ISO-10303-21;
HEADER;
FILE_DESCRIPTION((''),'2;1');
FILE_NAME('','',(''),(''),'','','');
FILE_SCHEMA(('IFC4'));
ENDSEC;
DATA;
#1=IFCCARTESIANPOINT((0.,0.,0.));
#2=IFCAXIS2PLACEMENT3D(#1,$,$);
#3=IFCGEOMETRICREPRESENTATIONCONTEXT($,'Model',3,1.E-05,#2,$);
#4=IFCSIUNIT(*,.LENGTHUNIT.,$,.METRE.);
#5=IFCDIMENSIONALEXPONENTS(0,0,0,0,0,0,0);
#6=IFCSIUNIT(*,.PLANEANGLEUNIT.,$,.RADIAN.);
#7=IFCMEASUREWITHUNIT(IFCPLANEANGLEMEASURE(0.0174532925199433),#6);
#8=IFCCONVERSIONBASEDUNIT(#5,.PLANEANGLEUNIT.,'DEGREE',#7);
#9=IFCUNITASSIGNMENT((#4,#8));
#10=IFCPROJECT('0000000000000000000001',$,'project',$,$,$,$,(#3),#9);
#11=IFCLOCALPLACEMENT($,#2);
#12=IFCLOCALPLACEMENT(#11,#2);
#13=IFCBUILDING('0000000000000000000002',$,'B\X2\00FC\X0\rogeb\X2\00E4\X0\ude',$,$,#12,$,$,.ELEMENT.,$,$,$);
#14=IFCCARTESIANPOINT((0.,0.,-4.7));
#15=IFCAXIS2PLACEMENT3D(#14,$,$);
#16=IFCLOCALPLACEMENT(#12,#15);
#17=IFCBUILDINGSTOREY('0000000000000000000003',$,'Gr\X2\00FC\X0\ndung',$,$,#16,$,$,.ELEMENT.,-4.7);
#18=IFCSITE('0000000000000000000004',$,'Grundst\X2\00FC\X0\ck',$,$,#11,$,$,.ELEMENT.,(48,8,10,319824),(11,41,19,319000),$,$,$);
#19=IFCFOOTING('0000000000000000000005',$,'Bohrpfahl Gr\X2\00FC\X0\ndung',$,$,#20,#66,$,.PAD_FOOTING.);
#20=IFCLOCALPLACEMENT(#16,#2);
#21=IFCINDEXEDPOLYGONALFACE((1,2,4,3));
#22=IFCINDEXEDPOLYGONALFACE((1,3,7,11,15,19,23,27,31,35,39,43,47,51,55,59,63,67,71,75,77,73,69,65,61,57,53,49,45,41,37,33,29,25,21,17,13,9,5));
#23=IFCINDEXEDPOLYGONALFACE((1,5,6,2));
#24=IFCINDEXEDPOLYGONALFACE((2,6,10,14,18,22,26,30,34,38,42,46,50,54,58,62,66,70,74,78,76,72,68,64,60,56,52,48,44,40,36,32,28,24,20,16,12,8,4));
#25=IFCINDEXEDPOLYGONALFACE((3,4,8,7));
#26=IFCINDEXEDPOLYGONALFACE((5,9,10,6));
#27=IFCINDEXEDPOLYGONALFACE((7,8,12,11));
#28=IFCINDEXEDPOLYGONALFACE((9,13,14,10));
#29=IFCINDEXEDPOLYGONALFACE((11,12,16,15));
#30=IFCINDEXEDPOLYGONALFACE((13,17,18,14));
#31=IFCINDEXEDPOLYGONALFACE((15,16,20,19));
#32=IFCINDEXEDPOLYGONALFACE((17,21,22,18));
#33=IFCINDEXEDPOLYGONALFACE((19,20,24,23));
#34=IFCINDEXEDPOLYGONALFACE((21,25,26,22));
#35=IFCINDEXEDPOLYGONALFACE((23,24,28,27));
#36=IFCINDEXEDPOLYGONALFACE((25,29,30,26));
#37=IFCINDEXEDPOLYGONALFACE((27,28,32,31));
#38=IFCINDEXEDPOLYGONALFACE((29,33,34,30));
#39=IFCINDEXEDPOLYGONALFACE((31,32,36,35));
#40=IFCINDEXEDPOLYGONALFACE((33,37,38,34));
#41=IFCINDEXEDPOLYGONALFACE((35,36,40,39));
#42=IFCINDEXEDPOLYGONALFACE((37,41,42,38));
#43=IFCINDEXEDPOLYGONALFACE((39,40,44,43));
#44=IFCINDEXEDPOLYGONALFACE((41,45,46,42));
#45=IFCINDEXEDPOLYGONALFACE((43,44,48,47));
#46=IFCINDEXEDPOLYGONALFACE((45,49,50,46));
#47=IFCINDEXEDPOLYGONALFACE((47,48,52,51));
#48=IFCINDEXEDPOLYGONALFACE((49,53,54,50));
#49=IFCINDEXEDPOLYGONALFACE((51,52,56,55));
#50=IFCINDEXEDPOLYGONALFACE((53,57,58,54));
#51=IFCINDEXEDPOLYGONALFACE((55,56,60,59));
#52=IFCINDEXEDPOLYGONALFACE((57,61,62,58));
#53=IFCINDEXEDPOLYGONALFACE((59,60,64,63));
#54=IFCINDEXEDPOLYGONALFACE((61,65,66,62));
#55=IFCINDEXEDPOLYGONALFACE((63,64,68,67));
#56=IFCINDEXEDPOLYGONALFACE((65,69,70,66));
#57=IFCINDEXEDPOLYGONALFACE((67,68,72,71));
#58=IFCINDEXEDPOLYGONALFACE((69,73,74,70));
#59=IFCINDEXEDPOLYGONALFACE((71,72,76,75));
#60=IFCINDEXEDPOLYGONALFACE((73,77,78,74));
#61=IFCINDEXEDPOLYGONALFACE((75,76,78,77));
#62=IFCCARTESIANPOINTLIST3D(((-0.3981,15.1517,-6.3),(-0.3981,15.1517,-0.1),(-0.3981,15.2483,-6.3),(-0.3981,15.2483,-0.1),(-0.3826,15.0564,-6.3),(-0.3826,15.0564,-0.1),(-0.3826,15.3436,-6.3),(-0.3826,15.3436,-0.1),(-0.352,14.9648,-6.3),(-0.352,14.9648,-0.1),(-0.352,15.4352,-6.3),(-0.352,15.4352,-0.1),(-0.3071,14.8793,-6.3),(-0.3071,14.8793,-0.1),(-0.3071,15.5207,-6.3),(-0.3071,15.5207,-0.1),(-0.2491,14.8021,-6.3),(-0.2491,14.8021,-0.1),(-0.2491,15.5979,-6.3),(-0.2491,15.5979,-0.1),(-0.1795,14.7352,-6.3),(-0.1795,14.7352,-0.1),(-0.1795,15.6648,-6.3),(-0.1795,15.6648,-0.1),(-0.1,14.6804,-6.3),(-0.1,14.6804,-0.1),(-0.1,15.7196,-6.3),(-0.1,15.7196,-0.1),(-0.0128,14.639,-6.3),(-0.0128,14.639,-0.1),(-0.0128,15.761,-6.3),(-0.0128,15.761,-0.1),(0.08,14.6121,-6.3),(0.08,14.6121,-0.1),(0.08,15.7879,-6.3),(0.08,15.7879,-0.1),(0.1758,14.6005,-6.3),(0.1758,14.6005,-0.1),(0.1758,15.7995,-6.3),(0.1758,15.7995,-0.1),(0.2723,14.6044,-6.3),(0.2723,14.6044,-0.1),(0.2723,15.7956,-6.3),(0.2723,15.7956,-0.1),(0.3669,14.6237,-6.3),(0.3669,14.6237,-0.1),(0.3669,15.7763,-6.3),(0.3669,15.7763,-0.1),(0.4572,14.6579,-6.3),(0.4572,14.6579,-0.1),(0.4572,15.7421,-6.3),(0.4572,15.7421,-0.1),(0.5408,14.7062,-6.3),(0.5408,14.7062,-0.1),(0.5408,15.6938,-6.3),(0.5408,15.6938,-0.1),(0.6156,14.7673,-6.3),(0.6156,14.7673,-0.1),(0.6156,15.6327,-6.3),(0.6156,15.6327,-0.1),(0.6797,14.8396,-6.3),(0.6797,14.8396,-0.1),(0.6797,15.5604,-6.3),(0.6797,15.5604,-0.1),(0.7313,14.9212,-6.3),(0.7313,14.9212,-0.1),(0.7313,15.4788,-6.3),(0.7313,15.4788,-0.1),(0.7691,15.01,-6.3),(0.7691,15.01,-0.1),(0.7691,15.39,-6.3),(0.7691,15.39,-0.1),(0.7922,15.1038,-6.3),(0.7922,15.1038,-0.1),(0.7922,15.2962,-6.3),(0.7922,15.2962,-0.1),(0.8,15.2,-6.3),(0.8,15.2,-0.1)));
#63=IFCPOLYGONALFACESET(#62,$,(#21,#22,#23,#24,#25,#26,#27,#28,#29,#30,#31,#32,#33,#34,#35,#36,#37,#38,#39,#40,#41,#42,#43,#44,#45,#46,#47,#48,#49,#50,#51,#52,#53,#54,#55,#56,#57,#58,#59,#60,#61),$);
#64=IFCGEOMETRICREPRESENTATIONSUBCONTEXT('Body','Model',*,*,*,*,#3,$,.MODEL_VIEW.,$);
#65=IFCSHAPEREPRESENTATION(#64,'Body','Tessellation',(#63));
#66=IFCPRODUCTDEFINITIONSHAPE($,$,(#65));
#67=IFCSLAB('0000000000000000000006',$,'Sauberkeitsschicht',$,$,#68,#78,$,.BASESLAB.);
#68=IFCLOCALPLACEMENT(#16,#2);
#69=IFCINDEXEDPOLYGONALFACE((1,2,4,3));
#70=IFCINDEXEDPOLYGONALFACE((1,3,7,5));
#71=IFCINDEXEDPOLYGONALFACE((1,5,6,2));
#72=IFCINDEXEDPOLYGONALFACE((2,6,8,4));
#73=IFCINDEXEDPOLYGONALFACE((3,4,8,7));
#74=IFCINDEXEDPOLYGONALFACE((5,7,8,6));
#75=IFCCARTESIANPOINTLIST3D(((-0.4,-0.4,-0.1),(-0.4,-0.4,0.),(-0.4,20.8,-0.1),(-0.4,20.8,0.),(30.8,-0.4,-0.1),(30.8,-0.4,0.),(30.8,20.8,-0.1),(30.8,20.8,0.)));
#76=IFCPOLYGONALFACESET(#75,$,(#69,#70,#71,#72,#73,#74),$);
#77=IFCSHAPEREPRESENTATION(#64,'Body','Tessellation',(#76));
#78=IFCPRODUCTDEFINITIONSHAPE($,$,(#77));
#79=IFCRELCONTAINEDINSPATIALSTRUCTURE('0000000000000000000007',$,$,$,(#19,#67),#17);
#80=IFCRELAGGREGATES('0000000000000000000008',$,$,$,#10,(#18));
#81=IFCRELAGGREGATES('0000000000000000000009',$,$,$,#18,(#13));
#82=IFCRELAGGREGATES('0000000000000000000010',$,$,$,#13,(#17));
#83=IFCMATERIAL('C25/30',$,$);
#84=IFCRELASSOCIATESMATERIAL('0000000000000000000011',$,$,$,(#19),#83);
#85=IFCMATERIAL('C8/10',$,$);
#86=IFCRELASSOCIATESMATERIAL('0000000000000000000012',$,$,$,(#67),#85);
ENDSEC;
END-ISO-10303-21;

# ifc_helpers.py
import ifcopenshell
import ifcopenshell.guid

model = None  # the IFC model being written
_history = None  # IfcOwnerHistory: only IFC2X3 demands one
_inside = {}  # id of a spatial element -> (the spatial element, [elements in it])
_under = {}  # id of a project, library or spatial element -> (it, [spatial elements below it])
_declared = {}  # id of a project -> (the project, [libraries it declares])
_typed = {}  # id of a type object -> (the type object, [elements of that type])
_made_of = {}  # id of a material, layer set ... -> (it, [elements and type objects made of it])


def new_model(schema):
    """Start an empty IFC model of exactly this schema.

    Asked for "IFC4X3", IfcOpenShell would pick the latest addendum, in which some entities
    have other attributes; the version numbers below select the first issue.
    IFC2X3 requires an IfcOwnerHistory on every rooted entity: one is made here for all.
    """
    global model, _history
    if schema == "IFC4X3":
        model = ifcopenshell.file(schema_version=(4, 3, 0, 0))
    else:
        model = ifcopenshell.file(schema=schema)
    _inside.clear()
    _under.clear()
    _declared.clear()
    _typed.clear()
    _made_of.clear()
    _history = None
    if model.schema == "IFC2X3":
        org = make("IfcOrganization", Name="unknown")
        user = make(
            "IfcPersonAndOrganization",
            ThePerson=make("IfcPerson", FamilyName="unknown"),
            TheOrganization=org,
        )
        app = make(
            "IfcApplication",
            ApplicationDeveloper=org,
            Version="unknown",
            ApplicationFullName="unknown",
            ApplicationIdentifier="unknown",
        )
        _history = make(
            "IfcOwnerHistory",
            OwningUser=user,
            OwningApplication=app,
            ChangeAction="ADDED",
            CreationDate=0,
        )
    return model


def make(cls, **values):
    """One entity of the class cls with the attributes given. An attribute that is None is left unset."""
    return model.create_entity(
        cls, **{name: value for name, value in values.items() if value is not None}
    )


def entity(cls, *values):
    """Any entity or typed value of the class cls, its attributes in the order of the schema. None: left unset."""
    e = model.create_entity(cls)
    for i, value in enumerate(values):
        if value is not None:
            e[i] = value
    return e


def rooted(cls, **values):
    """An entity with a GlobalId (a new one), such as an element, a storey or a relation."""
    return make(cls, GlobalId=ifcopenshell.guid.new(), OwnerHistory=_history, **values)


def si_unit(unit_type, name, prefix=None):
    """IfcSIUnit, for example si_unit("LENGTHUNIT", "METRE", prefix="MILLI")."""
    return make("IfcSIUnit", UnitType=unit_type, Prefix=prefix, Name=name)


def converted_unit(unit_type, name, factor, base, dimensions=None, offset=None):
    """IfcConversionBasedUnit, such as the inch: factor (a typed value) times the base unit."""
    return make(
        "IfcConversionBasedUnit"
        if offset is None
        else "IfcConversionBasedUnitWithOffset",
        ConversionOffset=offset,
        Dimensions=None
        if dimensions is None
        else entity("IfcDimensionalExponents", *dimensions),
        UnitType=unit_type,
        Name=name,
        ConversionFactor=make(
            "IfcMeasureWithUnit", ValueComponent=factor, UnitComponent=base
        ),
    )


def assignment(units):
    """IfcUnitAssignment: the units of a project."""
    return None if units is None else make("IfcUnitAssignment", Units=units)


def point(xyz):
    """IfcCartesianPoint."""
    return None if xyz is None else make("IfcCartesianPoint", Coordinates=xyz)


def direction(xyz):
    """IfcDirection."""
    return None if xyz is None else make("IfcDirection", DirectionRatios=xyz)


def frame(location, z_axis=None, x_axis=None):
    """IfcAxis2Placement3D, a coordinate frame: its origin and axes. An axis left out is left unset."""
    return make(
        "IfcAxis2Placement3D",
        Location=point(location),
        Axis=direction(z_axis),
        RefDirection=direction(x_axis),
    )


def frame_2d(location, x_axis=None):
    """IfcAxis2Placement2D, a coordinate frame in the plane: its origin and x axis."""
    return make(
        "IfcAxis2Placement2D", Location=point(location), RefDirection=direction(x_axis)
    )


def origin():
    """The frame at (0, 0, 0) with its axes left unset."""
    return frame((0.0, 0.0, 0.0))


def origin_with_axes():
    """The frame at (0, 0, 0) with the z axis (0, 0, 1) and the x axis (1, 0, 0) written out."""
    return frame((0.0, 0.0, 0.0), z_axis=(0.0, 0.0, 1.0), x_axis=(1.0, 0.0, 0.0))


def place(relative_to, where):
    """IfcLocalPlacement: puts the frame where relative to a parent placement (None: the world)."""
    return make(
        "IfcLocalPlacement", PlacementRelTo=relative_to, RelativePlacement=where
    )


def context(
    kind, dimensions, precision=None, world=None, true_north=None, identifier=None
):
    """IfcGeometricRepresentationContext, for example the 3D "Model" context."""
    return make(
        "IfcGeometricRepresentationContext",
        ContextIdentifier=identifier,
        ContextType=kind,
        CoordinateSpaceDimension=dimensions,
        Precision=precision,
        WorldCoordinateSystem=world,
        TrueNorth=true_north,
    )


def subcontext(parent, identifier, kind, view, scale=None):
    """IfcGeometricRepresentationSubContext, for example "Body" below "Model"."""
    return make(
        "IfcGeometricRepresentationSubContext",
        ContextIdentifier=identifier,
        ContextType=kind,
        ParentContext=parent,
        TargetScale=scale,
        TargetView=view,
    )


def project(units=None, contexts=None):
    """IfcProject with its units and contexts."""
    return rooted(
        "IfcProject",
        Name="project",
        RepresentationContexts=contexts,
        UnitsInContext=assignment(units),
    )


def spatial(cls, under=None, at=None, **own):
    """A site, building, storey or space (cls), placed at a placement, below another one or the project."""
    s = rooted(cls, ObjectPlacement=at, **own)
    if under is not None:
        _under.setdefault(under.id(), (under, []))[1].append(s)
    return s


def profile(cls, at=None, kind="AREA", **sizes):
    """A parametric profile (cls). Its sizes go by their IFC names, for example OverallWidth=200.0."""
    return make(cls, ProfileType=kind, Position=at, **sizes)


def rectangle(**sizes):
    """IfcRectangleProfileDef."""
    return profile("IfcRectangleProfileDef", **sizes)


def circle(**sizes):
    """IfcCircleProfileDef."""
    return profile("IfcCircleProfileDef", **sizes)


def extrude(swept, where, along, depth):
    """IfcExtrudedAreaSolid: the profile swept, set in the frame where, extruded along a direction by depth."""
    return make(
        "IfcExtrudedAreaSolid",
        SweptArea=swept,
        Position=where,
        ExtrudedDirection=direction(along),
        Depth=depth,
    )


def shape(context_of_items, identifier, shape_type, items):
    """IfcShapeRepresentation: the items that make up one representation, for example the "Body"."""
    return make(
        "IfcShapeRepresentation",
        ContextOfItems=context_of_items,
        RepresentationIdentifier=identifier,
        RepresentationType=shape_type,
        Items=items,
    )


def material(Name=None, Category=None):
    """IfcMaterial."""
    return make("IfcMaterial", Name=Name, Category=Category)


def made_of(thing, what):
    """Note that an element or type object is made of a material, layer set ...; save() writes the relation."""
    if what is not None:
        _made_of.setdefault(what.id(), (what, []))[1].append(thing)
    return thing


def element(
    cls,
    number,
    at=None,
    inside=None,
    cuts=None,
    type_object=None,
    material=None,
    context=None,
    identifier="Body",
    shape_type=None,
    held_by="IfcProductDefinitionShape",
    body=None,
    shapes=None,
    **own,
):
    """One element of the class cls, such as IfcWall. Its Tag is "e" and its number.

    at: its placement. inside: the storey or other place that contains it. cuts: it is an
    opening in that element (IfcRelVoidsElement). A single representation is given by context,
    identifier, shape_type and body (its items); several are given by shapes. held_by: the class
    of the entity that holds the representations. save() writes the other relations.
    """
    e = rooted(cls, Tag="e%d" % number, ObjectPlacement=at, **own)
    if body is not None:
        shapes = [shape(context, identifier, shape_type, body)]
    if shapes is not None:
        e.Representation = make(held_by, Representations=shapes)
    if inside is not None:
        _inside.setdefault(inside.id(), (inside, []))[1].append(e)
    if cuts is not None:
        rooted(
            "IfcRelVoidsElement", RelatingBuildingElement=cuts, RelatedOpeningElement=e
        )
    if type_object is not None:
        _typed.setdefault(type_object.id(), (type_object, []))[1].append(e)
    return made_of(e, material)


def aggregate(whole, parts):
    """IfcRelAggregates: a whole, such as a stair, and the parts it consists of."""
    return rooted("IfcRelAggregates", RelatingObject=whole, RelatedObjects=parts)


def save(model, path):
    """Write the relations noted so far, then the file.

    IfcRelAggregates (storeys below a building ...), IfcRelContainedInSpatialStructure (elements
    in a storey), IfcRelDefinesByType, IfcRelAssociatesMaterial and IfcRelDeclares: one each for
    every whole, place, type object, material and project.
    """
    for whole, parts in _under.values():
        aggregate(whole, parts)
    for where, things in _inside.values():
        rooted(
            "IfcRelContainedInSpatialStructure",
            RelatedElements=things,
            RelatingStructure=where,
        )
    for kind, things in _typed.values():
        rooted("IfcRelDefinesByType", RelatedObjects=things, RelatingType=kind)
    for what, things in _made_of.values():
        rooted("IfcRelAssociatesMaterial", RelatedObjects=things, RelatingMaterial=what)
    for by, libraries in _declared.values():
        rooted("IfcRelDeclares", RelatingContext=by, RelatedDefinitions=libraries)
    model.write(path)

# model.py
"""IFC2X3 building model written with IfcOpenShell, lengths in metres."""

from ifc_helpers import new_model, entity, si_unit, converted_unit, frame, frame_2d, origin, origin_with_axes, place, context, subcontext, project, spatial, rectangle, circle, extrude, material, element, save


model = new_model("IFC2X3")

# Units and contexts
model_context = context("Model", 3, precision=1e-05, world=origin())
body_context = subcontext(model_context, "Body", "Model", "MODEL_VIEW")
ifc_project = project(units=[si_unit("LENGTHUNIT", "METRE"), converted_unit("PLANEANGLEUNIT", "DEGREE", entity("IfcPlaneAngleMeasure", 0.0174532925199433), si_unit("PLANEANGLEUNIT", "RADIAN"), dimensions=[0, 0, 0, 0, 0, 0, 0])], contexts=[model_context])

# Site, building, storey
site_placement = place(None, origin())
site = spatial("IfcSite", under=ifc_project, at=site_placement, Name="Grundstück", CompositionType="ELEMENT", RefLatitude=(48, 8, 10, 319824), RefLongitude=(11, 41, 19, 319000))
building_placement = place(site_placement, origin())
building = spatial("IfcBuilding", under=site, at=building_placement, Name="Bürogebäude", CompositionType="ELEMENT")
storey_placement = place(building_placement, frame((0.0, 0.0, -4.7)))
storey = spatial("IfcBuildingStorey", under=building, at=storey_placement, Name="Gründung", CompositionType="ELEMENT", Elevation=-4.7)

# Footing
ifc_material_1 = material(Name="C25/30")
footing_1_placement = place(storey_placement, frame((-0.3975, 14.6025, -6.3)))
element("IfcFooting", 1, at=footing_1_placement, inside=storey, material=ifc_material_1, Name="Bohrpfahl Gründung", PredefinedType="PAD_FOOTING", context=body_context, shape_type="SweptSolid", body=[
    extrude(circle(Radius=0.6, at=frame_2d((0.6, 0.6), x_axis=(1.0, 0.0))), frame((-0.0025, -0.0025, 0.0), z_axis=(0.0, 0.0, 1.0), x_axis=(1.0, 0.0, 0.0)), (0.0, 0.0, 1.0), 6.2),
])

# Slab
ifc_material_2 = material(Name="C8/10")
slab_placement = place(storey_placement, frame((-0.4, -0.4, -0.1)))
element("IfcSlab", 2, at=slab_placement, inside=storey, material=ifc_material_2, Name="Sauberkeitsschicht", PredefinedType="BASESLAB", context=body_context, shape_type="SweptSolid", body=[
    extrude(rectangle(XDim=31.2, YDim=21.2, at=frame_2d((15.6, 10.6), x_axis=(1.0, 0.0))), origin_with_axes(), (0.0, 0.0, 1.0), 0.1),
])

save(model, "model.ifc")
